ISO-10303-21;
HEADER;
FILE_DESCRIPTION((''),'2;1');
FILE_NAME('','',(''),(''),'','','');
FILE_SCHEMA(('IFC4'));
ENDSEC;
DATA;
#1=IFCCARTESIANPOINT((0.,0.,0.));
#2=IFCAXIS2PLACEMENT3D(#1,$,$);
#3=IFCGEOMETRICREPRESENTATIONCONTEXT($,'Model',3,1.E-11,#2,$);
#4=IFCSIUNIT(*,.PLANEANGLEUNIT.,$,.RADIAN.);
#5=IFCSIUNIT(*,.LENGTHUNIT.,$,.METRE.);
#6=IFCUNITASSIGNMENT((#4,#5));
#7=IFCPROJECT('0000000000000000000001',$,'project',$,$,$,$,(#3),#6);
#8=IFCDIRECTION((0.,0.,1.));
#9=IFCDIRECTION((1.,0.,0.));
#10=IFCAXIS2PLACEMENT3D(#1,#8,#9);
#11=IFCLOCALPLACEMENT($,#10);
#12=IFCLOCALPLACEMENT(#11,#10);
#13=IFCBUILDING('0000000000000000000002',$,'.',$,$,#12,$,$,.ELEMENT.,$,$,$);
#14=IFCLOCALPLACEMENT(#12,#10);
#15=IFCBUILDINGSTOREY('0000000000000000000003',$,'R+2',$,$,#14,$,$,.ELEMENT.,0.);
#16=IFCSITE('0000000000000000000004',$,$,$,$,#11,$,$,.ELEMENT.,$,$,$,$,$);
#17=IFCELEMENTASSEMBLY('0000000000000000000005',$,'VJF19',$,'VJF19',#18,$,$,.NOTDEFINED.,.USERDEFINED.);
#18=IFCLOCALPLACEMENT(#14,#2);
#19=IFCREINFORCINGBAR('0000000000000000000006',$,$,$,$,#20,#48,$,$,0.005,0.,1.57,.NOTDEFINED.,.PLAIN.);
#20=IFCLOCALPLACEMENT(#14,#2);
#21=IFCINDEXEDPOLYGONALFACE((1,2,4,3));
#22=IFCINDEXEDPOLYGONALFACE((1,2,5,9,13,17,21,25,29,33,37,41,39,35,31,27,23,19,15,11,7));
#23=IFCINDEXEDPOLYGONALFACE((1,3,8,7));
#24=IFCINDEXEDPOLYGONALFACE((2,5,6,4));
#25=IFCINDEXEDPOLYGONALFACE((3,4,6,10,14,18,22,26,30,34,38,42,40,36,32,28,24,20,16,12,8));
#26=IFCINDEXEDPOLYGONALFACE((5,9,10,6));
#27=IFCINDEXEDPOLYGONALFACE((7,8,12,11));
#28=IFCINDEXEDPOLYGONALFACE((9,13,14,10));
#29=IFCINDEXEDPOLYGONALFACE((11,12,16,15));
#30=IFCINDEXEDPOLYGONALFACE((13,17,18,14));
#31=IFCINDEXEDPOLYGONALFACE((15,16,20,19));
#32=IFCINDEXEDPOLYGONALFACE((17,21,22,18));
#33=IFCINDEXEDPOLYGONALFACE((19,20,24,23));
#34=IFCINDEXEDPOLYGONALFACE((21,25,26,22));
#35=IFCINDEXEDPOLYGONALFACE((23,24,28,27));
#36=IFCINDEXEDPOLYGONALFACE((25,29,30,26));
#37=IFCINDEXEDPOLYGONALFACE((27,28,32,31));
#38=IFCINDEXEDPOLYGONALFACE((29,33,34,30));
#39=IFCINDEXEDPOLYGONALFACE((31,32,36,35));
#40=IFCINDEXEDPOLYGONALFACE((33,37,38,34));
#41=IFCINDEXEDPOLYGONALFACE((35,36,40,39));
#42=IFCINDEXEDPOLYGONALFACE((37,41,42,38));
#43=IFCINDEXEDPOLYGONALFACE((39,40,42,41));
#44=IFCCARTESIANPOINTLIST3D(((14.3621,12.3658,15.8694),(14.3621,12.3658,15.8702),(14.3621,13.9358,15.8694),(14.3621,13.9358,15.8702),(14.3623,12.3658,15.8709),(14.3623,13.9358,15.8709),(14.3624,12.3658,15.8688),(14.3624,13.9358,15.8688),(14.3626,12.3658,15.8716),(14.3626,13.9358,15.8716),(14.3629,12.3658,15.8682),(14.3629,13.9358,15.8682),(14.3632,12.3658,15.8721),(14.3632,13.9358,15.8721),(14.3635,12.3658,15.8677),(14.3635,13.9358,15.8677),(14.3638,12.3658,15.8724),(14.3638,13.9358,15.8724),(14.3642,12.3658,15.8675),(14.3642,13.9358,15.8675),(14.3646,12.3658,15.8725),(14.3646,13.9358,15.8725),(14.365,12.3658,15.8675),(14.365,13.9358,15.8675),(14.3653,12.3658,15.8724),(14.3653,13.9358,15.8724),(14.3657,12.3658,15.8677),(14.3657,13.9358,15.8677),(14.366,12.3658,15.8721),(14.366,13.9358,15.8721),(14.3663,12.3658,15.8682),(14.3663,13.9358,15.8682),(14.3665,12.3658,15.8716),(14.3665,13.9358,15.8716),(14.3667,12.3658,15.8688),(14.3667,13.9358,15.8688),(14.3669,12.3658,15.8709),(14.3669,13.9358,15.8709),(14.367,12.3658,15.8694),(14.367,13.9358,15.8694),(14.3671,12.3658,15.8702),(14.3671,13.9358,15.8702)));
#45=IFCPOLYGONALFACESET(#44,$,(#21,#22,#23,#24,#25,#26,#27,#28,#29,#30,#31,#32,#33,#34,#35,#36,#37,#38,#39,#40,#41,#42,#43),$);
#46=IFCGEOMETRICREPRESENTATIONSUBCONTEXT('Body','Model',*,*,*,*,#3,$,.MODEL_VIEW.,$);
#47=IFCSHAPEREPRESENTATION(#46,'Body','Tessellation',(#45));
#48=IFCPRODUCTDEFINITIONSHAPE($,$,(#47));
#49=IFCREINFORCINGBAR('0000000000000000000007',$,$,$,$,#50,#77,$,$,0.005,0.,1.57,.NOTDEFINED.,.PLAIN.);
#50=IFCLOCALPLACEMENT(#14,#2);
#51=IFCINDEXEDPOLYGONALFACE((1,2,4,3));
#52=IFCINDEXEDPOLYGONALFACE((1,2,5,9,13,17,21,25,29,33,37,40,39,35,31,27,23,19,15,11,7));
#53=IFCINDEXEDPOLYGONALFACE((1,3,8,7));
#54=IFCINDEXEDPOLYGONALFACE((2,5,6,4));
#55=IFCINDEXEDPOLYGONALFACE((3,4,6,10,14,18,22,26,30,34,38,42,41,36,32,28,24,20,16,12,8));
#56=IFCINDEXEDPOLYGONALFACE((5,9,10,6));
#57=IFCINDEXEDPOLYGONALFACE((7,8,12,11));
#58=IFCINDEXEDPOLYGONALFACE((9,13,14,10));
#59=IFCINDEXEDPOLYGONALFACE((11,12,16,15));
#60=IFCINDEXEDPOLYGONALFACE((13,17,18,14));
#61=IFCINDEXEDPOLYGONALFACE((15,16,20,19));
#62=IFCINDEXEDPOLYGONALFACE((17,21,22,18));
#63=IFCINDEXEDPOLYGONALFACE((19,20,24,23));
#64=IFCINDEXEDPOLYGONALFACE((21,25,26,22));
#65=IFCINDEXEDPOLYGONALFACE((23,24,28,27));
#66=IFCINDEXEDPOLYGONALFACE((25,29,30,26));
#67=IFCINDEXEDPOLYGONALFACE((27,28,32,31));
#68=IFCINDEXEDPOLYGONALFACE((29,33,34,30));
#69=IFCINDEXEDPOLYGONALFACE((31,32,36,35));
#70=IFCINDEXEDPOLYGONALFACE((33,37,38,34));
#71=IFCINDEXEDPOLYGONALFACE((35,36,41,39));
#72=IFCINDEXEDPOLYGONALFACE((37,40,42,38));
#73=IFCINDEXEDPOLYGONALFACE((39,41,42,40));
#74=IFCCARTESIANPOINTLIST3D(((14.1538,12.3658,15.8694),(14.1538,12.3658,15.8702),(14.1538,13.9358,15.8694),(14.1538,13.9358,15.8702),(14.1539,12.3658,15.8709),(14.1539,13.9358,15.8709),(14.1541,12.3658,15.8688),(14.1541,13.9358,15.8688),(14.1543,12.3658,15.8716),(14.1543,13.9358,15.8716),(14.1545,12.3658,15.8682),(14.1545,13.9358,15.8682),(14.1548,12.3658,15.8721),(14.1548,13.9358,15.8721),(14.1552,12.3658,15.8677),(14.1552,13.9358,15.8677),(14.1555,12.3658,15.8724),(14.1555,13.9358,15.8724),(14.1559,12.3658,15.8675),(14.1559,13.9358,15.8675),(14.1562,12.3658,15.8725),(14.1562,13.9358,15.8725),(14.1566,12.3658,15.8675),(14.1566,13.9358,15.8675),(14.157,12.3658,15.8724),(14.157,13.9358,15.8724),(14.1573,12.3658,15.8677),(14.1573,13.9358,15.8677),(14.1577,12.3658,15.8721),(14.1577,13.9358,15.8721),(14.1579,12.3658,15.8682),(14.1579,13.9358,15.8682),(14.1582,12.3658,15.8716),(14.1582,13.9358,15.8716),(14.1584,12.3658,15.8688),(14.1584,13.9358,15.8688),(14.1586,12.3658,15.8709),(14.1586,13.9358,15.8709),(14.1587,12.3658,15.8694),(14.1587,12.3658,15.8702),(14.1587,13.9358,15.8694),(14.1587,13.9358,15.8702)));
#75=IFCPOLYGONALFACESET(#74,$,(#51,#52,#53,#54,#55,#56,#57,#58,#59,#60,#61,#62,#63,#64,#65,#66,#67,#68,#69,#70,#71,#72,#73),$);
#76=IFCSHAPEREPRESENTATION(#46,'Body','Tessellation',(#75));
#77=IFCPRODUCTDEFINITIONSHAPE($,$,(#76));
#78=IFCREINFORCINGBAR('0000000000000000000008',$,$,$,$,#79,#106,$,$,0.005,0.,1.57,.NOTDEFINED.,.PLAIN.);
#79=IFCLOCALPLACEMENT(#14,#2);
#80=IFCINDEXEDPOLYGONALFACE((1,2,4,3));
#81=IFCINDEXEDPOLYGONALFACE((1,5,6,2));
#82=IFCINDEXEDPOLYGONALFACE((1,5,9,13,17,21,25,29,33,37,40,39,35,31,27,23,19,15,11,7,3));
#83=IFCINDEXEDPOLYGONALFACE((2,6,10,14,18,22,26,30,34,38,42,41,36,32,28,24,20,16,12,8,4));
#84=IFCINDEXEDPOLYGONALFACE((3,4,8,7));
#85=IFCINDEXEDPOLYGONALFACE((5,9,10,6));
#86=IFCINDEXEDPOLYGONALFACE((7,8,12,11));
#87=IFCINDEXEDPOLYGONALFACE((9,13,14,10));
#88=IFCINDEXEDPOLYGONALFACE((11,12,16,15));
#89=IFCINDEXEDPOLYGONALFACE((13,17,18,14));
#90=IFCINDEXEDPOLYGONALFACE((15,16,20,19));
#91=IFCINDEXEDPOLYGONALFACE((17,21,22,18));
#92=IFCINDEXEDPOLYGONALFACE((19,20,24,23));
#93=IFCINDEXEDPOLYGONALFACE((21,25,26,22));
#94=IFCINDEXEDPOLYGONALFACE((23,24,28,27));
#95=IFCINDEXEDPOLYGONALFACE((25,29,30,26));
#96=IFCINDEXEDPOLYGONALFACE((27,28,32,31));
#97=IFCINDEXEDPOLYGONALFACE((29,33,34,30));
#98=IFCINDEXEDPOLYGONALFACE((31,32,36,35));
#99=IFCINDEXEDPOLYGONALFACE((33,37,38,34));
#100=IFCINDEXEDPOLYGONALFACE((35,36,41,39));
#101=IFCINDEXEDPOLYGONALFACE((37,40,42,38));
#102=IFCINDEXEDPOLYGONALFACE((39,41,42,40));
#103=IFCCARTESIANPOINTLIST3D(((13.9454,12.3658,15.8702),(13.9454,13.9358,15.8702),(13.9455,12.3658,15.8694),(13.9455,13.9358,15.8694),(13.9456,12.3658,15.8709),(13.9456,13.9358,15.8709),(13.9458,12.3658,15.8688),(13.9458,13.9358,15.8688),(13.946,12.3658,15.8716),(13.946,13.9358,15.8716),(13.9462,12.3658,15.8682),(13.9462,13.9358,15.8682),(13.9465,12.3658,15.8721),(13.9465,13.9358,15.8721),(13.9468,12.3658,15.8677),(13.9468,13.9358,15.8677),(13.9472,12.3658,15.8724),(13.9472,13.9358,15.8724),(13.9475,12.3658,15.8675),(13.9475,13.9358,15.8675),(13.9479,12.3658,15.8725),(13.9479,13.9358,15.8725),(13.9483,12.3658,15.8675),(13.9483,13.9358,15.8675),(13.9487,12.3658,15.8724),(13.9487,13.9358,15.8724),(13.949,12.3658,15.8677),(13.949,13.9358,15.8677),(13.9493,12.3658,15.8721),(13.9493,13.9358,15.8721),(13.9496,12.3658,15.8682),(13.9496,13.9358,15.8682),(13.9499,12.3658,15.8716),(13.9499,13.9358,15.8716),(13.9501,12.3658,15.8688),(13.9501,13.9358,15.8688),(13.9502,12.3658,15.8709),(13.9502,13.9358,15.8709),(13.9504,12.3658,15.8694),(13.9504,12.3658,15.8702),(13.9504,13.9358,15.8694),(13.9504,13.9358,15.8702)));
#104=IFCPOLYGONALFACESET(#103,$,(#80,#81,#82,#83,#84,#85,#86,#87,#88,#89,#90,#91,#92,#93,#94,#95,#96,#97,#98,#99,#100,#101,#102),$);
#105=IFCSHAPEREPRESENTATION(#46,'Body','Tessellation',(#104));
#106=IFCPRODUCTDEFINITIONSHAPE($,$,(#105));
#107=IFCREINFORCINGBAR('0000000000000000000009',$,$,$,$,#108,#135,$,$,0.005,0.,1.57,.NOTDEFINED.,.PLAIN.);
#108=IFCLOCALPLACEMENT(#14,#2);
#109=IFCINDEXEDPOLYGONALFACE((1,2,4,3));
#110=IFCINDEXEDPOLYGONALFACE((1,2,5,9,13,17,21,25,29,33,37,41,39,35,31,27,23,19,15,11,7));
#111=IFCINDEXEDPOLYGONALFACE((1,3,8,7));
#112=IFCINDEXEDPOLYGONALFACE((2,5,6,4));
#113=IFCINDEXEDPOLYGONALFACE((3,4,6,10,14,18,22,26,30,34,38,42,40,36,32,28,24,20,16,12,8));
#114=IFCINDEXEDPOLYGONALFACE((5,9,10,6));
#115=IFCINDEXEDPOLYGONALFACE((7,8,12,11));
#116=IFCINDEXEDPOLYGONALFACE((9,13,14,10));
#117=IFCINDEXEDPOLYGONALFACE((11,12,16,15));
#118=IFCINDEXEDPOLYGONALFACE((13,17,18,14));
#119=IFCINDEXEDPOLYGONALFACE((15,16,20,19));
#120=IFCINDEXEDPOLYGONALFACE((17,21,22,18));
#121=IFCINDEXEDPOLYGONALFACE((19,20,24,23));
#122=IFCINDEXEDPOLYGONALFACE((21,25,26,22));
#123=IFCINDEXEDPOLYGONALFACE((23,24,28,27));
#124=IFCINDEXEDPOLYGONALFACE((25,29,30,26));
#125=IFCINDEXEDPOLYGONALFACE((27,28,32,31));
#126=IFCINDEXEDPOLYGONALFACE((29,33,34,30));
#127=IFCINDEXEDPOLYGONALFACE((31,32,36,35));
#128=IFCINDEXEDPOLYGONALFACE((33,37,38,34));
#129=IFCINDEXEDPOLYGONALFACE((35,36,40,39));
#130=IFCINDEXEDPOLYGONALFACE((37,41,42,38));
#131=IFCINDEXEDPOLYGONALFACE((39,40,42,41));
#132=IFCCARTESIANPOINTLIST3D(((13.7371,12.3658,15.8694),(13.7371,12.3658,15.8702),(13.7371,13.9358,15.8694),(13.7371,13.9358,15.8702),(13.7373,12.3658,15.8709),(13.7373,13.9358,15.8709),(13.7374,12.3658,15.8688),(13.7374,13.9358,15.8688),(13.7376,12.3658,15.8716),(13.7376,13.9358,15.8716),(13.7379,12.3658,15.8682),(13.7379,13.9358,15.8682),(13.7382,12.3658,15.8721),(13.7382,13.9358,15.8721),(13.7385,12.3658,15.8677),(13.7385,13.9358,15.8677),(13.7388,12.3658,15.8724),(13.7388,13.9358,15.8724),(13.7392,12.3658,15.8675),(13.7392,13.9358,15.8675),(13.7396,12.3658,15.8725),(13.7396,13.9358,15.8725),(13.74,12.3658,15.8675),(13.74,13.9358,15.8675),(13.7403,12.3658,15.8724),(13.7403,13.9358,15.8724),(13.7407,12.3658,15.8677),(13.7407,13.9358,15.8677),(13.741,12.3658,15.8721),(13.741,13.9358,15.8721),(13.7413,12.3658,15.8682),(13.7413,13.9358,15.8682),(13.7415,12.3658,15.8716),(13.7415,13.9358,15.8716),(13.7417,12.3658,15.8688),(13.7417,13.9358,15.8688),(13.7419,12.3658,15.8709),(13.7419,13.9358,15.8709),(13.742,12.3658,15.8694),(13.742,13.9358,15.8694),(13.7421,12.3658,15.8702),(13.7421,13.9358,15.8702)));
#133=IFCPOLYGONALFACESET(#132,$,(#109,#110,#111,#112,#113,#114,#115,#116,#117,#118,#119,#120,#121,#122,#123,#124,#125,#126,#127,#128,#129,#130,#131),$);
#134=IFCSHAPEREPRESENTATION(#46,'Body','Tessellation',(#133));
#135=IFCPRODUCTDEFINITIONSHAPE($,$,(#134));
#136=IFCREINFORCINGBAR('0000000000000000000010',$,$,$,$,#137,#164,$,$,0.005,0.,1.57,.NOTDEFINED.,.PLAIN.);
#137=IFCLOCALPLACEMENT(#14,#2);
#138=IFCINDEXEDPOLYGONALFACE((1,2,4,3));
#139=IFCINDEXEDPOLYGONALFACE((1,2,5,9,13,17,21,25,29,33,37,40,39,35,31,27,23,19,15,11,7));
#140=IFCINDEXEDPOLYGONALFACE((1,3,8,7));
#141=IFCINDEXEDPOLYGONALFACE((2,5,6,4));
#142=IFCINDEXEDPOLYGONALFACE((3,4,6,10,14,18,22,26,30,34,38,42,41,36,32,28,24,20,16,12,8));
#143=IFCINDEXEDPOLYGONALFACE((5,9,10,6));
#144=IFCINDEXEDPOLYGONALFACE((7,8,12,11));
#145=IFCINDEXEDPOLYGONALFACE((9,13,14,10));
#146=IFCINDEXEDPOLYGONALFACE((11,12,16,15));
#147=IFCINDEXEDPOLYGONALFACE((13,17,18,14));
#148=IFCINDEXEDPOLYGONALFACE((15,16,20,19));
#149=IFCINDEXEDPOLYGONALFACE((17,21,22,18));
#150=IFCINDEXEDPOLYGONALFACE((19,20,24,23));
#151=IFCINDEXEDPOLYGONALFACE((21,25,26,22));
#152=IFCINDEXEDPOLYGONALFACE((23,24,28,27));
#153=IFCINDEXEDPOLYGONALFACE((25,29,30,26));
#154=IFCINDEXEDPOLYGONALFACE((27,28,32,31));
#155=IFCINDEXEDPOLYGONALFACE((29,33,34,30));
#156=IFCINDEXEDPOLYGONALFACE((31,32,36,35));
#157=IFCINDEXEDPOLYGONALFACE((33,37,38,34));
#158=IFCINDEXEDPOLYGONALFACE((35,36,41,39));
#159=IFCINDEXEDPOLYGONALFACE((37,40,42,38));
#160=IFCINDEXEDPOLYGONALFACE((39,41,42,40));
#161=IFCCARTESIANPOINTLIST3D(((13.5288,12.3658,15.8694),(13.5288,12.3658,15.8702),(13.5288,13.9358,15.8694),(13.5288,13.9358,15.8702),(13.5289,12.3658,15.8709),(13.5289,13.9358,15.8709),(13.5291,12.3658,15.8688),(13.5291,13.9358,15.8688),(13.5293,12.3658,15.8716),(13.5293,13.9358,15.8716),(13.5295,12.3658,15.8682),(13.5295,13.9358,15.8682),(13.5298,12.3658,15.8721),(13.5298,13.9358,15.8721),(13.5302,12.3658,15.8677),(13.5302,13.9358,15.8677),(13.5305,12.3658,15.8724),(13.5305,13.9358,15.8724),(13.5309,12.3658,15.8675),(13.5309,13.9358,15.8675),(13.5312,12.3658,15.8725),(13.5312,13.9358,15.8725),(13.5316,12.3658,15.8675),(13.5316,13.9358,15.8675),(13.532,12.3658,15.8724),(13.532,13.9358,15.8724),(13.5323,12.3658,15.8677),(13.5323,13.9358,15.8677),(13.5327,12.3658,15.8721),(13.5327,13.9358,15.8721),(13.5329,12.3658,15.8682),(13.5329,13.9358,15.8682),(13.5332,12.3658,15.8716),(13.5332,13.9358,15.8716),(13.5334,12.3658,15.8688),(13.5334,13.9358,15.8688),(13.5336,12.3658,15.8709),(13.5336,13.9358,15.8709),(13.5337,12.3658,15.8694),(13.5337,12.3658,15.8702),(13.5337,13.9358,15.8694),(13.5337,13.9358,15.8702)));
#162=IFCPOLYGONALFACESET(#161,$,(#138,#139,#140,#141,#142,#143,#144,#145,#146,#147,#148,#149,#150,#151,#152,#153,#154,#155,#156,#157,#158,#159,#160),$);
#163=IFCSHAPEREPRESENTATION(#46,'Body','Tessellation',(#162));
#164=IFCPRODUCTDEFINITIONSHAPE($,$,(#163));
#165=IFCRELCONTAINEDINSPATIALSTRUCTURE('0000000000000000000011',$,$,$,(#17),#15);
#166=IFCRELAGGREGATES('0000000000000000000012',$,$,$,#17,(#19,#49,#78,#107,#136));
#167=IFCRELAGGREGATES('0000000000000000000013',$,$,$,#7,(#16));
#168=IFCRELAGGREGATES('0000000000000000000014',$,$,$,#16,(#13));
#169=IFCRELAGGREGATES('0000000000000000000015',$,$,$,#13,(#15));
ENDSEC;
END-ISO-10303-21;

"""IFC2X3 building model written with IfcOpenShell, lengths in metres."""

from ifc_helpers import new_model, entity, si_unit, origin, origin_with_axes, place, context, subcontext, project, spatial, shape, element, aggregate, save


model = new_model("IFC2X3")

# Units and contexts
model_context = context("Model", 3, precision=1e-11, world=origin())
body_context = subcontext(model_context, "Body", "Model", "MODEL_VIEW")
ifc_project = project(units=[si_unit("PLANEANGLEUNIT", "RADIAN"), si_unit("LENGTHUNIT", "METRE")], contexts=[model_context])

# Site, building, storey
site_placement = place(None, origin_with_axes())
site = spatial("IfcSite", under=ifc_project, at=site_placement, CompositionType="ELEMENT")
building_placement = place(site_placement, origin_with_axes())
building = spatial("IfcBuilding", under=site, at=building_placement, Name=".", CompositionType="ELEMENT")
storey_placement = place(building_placement, origin_with_axes())
storey = spatial("IfcBuildingStorey", under=building, at=storey_placement, Name="R+2", CompositionType="ELEMENT", Elevation=0.0)

# Element assembly, reinforcing bars
assembly_1_placement = place(storey_placement, origin_with_axes())
assembly_1 = element("IfcElementAssembly", 1, at=assembly_1_placement, inside=storey, Name="VJF19", ObjectType="VJF19", AssemblyPlace="NOTDEFINED", PredefinedType="USERDEFINED")
reinforcing_bar_1_placement = place(assembly_1_placement, origin_with_axes())
reinforcing_bar_1 = element("IfcReinforcingBar", 2, at=reinforcing_bar_1_placement, BarLength=1.57, BarRole="NOTDEFINED", BarSurface="PLAIN", CrossSectionArea=0.0, NominalDiameter=0.005, shapes=[
    shape(body_context, "Body", "AdvancedSweptSolid", [entity("IfcSweptDiskSolid", entity("IfcPolyline", [entity("IfcCartesianPoint", [14.3646, 12.3658, 15.87]), entity("IfcCartesianPoint", [14.3646, 13.9358, 15.87])]), 0.0025, None, 0.0, 1.57)]),
    shape(body_context, "Body", "AdvancedSweptSolid", [entity("IfcSweptDiskSolid", entity("IfcPolyline", [entity("IfcCartesianPoint", [14.3646, 12.3658, 15.87]), entity("IfcCartesianPoint", [14.3646, 13.9358, 15.87])]), 0.0025, None, 0.0, 1.57)]),
])
reinforcing_bar_2_placement = place(assembly_1_placement, origin_with_axes())
reinforcing_bar_2 = element("IfcReinforcingBar", 3, at=reinforcing_bar_2_placement, BarLength=1.57, BarRole="NOTDEFINED", BarSurface="PLAIN", CrossSectionArea=0.0, NominalDiameter=0.005, shapes=[
    shape(body_context, "Body", "AdvancedSweptSolid", [entity("IfcSweptDiskSolid", entity("IfcPolyline", [entity("IfcCartesianPoint", [14.1562, 12.3658, 15.87]), entity("IfcCartesianPoint", [14.1562, 13.9358, 15.87])]), 0.0025, None, 0.0, 1.57)]),
    shape(body_context, "Body", "AdvancedSweptSolid", [entity("IfcSweptDiskSolid", entity("IfcPolyline", [entity("IfcCartesianPoint", [14.1562, 12.3658, 15.87]), entity("IfcCartesianPoint", [14.1562, 13.9358, 15.87])]), 0.0025, None, 0.0, 1.57)]),
])
reinforcing_bar_3_placement = place(assembly_1_placement, origin_with_axes())
reinforcing_bar_3 = element("IfcReinforcingBar", 4, at=reinforcing_bar_3_placement, BarLength=1.57, BarRole="NOTDEFINED", BarSurface="PLAIN", CrossSectionArea=0.0, NominalDiameter=0.005, shapes=[
    shape(body_context, "Body", "AdvancedSweptSolid", [entity("IfcSweptDiskSolid", entity("IfcPolyline", [entity("IfcCartesianPoint", [13.9479, 12.3658, 15.87]), entity("IfcCartesianPoint", [13.9479, 13.9358, 15.87])]), 0.0025, None, 0.0, 1.57)]),
    shape(body_context, "Body", "AdvancedSweptSolid", [entity("IfcSweptDiskSolid", entity("IfcPolyline", [entity("IfcCartesianPoint", [13.9479, 12.3658, 15.87]), entity("IfcCartesianPoint", [13.9479, 13.9358, 15.87])]), 0.0025, None, 0.0, 1.57)]),
])
reinforcing_bar_4_placement = place(assembly_1_placement, origin_with_axes())
reinforcing_bar_4 = element("IfcReinforcingBar", 5, at=reinforcing_bar_4_placement, BarLength=1.57, BarRole="NOTDEFINED", BarSurface="PLAIN", CrossSectionArea=0.0, NominalDiameter=0.005, shapes=[
    shape(body_context, "Body", "AdvancedSweptSolid", [entity("IfcSweptDiskSolid", entity("IfcPolyline", [entity("IfcCartesianPoint", [13.7396, 12.3658, 15.87]), entity("IfcCartesianPoint", [13.7396, 13.9358, 15.87])]), 0.0025, None, 0.0, 1.57)]),
    shape(body_context, "Body", "AdvancedSweptSolid", [entity("IfcSweptDiskSolid", entity("IfcPolyline", [entity("IfcCartesianPoint", [13.7396, 12.3658, 15.87]), entity("IfcCartesianPoint", [13.7396, 13.9358, 15.87])]), 0.0025, None, 0.0, 1.57)]),
])
reinforcing_bar_5_placement = place(assembly_1_placement, origin_with_axes())
reinforcing_bar_5 = element("IfcReinforcingBar", 6, at=reinforcing_bar_5_placement, BarLength=1.57, BarRole="NOTDEFINED", BarSurface="PLAIN", CrossSectionArea=0.0, NominalDiameter=0.005, shapes=[
    shape(body_context, "Body", "AdvancedSweptSolid", [entity("IfcSweptDiskSolid", entity("IfcPolyline", [entity("IfcCartesianPoint", [13.5312, 12.3658, 15.87]), entity("IfcCartesianPoint", [13.5312, 13.9358, 15.87])]), 0.0025, None, 0.0, 1.57)]),
    shape(body_context, "Body", "AdvancedSweptSolid", [entity("IfcSweptDiskSolid", entity("IfcPolyline", [entity("IfcCartesianPoint", [13.5312, 12.3658, 15.87]), entity("IfcCartesianPoint", [13.5312, 13.9358, 15.87])]), 0.0025, None, 0.0, 1.57)]),
])
aggregate(assembly_1, [reinforcing_bar_1, reinforcing_bar_2, reinforcing_bar_3, reinforcing_bar_4, reinforcing_bar_5])

save(model, "model.ifc")
